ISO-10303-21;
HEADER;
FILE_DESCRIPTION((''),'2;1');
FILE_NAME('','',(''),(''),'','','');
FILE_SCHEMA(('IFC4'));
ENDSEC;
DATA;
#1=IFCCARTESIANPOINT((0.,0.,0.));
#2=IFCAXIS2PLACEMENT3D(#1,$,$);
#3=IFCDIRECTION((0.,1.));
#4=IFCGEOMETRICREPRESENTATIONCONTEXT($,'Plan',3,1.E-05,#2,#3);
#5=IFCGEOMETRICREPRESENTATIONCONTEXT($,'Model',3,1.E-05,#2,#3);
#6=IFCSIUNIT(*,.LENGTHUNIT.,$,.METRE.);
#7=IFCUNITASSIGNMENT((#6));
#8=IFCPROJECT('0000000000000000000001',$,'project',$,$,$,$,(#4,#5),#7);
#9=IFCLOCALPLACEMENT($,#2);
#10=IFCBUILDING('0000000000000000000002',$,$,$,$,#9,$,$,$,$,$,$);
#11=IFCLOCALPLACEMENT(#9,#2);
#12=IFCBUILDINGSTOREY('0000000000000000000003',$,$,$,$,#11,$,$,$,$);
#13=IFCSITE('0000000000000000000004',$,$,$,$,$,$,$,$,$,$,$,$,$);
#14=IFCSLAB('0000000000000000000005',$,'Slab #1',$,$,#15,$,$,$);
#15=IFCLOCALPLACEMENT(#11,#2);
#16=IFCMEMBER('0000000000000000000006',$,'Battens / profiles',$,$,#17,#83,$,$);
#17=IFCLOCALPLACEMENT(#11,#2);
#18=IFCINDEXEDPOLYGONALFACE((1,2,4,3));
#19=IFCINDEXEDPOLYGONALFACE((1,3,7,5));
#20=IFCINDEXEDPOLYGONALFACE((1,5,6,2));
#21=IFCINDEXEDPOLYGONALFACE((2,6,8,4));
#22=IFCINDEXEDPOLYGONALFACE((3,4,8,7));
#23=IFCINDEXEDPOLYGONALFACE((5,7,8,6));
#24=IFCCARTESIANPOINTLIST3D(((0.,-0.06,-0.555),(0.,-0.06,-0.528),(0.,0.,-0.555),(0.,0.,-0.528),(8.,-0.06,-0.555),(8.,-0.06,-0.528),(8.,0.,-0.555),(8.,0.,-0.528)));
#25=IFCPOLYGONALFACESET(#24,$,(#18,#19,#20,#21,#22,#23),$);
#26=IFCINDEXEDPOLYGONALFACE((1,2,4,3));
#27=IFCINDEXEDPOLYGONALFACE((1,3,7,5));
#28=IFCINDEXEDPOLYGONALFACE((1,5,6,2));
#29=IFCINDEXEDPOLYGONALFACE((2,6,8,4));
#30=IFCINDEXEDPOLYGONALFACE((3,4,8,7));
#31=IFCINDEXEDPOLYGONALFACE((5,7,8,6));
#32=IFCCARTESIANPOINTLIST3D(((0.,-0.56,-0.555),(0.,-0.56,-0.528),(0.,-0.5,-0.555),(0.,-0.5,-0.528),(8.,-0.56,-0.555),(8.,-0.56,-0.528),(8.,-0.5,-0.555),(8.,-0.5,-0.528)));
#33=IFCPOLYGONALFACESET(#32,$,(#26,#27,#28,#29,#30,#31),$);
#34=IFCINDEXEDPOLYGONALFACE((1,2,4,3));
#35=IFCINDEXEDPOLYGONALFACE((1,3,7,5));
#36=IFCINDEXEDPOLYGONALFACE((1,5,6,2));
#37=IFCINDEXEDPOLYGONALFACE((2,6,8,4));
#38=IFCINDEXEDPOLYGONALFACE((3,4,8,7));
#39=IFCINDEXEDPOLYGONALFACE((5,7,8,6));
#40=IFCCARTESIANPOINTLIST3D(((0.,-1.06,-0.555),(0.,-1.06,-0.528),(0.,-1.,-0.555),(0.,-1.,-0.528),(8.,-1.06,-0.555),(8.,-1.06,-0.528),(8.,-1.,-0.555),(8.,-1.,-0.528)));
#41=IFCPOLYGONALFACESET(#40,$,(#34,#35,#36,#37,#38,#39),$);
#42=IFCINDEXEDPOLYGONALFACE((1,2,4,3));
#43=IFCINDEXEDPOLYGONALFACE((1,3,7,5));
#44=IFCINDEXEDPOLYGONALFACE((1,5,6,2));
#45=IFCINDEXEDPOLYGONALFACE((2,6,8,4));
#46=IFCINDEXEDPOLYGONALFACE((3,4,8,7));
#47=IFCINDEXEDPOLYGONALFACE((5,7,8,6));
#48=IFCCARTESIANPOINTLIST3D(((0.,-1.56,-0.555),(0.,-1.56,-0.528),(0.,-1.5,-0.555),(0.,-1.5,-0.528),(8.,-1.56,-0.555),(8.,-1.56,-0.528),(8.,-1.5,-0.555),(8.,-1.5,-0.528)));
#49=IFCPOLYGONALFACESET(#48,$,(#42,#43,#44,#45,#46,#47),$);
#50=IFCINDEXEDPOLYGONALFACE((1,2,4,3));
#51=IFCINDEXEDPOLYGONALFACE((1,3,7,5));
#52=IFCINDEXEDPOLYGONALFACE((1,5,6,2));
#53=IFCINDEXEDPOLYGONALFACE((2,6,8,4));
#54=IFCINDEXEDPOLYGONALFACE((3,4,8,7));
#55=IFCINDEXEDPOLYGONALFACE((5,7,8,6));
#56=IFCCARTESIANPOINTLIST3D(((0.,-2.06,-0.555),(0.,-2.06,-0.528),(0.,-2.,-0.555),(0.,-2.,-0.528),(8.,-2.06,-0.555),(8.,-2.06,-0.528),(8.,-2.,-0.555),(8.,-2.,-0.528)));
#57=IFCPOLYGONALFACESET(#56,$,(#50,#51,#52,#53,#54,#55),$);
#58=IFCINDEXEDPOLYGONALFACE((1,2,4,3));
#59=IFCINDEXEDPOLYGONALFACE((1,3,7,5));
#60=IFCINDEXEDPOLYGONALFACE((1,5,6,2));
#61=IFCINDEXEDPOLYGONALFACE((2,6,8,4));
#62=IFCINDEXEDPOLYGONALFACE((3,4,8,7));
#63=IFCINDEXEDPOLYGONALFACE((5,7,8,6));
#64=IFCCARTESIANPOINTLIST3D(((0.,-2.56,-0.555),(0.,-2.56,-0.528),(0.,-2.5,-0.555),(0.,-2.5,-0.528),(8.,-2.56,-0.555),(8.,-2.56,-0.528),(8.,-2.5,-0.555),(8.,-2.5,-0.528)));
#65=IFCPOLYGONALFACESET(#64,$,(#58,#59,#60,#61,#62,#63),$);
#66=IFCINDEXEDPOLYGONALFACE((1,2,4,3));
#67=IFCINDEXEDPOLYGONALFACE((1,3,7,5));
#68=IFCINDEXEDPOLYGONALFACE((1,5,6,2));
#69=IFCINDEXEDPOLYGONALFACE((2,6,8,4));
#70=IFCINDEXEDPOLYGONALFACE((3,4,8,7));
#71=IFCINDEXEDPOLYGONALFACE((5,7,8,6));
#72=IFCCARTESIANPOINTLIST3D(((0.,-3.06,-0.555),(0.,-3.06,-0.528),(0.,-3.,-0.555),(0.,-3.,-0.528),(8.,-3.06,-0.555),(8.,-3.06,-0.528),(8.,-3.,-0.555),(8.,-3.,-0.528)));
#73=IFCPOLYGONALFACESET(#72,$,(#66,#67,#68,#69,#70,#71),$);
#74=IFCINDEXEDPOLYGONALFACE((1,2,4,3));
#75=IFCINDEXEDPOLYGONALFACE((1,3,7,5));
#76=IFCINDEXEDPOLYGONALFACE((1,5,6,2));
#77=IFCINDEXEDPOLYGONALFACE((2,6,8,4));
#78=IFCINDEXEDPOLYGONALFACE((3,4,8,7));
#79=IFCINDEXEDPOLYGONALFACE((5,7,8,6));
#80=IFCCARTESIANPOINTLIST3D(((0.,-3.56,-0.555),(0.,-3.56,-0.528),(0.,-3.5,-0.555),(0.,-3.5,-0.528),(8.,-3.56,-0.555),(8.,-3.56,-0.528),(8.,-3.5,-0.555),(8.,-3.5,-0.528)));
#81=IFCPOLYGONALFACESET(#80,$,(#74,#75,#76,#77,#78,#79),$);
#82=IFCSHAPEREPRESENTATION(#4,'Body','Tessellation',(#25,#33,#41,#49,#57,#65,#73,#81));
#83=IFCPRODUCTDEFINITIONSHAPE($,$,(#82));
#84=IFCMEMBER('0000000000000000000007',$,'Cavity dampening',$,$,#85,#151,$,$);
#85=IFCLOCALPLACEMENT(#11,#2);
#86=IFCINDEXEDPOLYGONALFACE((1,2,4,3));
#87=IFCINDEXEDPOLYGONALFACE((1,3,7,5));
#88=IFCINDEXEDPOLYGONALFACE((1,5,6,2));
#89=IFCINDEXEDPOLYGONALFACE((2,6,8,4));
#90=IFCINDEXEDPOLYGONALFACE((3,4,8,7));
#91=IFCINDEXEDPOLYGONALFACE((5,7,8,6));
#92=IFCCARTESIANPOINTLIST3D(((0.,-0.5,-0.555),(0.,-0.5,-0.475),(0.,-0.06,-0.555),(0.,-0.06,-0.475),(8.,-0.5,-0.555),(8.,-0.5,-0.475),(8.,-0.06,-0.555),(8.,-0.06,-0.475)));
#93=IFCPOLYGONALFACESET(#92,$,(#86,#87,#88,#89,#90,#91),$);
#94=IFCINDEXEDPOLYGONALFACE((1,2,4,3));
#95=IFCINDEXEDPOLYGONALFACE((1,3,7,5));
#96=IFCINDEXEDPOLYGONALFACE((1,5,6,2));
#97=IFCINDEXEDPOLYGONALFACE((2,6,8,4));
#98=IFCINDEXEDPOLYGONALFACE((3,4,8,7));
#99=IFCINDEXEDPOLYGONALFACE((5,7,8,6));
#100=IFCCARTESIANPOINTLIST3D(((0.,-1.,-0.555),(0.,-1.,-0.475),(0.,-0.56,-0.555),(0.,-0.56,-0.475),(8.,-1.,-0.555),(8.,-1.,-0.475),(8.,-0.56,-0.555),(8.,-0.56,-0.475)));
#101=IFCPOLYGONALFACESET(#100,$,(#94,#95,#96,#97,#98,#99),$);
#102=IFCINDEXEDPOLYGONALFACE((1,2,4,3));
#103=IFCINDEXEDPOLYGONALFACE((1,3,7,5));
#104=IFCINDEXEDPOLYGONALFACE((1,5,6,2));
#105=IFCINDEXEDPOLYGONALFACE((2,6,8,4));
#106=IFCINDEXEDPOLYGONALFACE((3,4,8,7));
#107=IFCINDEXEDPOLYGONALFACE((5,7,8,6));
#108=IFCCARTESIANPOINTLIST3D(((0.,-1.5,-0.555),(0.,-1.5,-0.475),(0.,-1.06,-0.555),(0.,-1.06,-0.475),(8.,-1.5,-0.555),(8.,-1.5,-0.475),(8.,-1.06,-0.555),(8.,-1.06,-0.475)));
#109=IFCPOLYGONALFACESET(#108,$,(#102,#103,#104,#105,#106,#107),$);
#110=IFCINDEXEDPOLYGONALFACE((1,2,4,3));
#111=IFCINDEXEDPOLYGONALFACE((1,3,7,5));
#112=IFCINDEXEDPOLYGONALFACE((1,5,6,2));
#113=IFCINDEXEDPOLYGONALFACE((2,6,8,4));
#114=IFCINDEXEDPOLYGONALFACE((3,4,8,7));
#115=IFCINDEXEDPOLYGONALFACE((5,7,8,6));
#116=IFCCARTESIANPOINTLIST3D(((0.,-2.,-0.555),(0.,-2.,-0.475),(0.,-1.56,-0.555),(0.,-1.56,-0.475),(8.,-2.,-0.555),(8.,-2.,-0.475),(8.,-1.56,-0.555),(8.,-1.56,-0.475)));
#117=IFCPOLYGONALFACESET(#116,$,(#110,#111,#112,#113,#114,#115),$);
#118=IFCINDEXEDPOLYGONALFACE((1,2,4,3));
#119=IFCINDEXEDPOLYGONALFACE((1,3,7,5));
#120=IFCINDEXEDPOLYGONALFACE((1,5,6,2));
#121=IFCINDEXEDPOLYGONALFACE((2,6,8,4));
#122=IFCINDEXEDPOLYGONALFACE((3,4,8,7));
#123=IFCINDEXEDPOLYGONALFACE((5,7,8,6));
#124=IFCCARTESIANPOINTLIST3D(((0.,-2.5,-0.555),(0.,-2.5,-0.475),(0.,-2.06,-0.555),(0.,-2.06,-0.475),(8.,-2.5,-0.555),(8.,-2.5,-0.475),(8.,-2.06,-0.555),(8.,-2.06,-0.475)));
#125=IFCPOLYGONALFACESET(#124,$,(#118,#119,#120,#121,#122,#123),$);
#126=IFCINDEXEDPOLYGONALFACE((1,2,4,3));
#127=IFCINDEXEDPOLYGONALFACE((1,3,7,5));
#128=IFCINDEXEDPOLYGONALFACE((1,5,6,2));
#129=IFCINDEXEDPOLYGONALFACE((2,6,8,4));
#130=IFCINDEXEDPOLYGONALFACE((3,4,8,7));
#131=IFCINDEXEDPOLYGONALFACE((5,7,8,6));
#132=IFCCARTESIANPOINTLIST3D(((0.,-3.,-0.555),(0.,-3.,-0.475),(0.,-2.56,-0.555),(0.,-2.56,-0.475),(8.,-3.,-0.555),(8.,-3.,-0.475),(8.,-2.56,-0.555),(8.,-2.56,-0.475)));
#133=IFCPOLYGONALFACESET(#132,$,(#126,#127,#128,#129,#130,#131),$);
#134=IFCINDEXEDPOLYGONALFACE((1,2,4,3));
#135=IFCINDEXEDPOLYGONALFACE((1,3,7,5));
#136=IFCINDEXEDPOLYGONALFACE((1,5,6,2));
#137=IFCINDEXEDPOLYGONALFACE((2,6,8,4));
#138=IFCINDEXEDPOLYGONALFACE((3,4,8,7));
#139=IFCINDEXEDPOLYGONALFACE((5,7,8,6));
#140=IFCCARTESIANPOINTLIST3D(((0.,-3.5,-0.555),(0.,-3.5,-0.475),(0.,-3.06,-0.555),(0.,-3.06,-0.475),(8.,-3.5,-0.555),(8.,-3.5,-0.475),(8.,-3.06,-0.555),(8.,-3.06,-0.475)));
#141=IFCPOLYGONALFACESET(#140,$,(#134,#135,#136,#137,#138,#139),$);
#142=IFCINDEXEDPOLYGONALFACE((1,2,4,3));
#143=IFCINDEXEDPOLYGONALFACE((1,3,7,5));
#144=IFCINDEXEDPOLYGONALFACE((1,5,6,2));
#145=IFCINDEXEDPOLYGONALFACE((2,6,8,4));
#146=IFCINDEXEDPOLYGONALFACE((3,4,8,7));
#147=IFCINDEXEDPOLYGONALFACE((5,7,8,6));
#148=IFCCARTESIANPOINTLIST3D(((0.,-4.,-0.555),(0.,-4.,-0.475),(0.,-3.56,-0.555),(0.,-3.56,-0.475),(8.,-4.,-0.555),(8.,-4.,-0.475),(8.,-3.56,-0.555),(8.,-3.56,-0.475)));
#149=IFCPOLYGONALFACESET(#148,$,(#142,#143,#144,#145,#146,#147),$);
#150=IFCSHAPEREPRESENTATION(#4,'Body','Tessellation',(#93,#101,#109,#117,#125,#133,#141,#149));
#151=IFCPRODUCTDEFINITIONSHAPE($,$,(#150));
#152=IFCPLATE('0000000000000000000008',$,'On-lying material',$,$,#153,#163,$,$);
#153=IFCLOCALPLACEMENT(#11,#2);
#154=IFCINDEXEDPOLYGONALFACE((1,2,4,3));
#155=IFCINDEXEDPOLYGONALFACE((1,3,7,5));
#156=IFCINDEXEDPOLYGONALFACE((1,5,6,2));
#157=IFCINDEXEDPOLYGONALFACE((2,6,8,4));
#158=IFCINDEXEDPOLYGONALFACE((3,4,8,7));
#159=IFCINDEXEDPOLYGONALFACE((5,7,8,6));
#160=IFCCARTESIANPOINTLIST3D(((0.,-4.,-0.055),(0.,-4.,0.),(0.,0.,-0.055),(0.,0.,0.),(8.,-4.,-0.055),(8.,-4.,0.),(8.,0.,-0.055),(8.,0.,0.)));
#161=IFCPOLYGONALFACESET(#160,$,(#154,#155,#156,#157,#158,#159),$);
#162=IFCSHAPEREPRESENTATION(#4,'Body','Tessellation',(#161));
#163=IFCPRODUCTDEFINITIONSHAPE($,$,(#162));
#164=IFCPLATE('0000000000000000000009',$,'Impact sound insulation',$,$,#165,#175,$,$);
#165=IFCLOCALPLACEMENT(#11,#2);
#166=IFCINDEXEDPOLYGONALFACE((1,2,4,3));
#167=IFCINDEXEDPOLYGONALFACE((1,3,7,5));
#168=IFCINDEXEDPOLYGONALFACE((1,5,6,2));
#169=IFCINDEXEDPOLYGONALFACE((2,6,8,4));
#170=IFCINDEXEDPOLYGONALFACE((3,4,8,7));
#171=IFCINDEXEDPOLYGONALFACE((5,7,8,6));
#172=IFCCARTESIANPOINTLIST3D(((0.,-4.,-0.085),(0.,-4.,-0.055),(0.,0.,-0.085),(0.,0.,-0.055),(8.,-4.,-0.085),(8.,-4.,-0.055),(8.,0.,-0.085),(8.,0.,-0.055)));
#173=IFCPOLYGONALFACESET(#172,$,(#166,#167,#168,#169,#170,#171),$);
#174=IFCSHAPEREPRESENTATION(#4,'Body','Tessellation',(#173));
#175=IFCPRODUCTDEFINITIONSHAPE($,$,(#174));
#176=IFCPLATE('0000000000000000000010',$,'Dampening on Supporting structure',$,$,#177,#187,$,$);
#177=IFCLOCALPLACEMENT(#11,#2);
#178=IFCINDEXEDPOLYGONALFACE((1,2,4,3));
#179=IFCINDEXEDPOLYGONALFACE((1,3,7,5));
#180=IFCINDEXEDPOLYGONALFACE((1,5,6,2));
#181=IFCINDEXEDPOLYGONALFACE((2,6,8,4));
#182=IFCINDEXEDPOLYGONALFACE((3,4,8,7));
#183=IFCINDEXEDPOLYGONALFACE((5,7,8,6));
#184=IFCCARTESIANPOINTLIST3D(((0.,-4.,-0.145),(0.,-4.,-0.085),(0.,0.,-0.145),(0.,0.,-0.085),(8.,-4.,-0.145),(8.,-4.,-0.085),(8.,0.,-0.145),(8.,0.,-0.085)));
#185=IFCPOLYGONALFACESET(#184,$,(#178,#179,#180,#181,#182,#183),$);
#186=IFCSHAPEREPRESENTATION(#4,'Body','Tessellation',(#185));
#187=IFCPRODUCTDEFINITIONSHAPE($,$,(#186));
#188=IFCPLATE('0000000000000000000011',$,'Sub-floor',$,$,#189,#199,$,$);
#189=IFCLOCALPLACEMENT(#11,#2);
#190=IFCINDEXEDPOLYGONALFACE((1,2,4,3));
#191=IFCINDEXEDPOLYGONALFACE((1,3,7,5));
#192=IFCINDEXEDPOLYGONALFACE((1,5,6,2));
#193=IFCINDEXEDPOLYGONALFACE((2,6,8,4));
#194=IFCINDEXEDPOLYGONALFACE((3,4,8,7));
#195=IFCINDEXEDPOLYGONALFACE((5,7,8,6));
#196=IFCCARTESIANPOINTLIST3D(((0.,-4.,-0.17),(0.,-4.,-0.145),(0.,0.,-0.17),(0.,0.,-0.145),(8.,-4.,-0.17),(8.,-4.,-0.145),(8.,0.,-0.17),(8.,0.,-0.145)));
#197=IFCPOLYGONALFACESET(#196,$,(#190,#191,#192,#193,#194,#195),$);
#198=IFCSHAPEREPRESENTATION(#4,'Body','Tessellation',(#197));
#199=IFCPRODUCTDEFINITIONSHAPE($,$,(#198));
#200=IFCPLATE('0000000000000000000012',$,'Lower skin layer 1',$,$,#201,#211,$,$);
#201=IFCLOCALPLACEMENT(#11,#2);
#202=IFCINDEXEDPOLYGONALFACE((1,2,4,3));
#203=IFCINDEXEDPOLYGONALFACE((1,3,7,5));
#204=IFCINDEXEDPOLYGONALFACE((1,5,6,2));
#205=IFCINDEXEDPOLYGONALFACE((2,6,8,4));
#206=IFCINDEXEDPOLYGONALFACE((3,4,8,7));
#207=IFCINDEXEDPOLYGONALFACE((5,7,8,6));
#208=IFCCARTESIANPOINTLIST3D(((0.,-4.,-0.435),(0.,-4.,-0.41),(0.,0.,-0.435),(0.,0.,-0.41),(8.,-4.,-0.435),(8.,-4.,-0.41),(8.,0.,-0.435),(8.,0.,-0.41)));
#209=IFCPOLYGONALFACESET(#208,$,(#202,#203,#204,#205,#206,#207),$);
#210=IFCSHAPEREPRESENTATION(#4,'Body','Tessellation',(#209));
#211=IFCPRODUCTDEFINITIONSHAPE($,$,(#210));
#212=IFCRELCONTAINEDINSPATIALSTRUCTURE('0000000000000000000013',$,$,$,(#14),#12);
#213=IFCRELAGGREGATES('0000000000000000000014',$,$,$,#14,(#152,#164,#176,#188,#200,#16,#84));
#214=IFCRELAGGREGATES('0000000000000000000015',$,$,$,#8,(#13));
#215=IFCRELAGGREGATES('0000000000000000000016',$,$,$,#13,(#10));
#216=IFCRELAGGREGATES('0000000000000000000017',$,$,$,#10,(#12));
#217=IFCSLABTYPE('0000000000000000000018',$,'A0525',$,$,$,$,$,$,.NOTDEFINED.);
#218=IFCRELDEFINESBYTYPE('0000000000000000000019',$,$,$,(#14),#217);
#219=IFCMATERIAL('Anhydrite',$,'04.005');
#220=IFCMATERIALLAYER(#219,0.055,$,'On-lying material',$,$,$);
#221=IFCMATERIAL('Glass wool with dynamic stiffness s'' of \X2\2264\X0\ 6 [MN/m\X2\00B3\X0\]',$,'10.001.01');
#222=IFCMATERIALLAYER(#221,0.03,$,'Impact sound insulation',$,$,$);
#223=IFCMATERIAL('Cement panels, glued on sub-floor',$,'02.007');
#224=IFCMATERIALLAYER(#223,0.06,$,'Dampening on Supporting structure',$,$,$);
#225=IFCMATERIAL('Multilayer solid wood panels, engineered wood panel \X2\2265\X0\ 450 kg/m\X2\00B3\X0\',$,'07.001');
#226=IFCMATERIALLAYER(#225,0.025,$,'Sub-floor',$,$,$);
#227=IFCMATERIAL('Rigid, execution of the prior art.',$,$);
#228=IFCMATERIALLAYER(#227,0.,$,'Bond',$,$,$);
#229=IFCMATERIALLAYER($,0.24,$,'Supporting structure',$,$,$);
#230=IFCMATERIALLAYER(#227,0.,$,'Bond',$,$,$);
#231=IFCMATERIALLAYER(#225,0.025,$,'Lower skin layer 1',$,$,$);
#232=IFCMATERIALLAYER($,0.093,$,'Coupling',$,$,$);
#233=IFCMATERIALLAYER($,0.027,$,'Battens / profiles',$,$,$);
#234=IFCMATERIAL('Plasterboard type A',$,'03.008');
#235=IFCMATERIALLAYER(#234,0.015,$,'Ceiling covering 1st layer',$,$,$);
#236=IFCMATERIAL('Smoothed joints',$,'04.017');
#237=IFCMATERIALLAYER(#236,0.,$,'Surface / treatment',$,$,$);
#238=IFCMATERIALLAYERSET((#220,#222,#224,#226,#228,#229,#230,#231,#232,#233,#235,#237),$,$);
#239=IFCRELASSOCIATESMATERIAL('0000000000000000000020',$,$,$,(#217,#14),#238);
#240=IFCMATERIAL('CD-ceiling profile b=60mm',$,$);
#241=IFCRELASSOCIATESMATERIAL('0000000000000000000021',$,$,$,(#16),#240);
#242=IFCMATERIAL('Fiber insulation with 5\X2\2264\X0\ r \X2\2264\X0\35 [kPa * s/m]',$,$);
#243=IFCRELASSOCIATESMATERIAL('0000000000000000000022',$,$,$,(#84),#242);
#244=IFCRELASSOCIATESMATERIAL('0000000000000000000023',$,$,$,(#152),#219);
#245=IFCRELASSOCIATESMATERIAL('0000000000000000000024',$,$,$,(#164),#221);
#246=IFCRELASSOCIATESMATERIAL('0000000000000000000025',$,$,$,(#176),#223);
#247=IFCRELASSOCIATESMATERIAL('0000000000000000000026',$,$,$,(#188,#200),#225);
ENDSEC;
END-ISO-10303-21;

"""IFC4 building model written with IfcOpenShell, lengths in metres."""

from ifc_helpers import new_model, si_unit, direction, frame, frame_2d, origin, origin_with_axes, place, context, project, spatial, rectangle, extrude, material, layer, layer_set, type_object, element, aggregate, save


model = new_model("IFC4")

# Units and contexts
plan_context = context("Plan", 3, precision=1e-05, world=origin(), true_north=direction((0.0, 1.0)))
model_context = context("Model", 3, precision=1e-05, world=origin(), true_north=direction((0.0, 1.0)))
ifc_project = project(units=[si_unit("LENGTHUNIT", "METRE")], contexts=[plan_context, model_context])

# Site, building, storey
site = spatial("IfcSite", under=ifc_project)
building_placement = place(None, origin())
building = spatial("IfcBuilding", under=site, at=building_placement)
storey_placement = place(building_placement, origin())
storey = spatial("IfcBuildingStorey", under=building, at=storey_placement)

# Slab, members, plates
ifc_material_1 = material(Name="Anhydrite", Category="04.005")
ifc_layer_1 = layer(ifc_material_1, 0.055, Name="On-lying material")
ifc_material_2 = material(Name="Glass wool with dynamic stiffness s' of ≤ 6 [MN/m³]", Category="10.001.01")
ifc_layer_2 = layer(ifc_material_2, 0.03, Name="Impact sound insulation")
ifc_material_3 = material(Name="Cement panels, glued on sub-floor", Category="02.007")
ifc_layer_3 = layer(ifc_material_3, 0.06, Name="Dampening on Supporting structure")
ifc_material_4 = material(Name="Multilayer solid wood panels, engineered wood panel ≥ 450 kg/m³", Category="07.001")
ifc_layer_4 = layer(ifc_material_4, 0.025, Name="Sub-floor")
ifc_material_5 = material(Name="Rigid, execution of the prior art.")
ifc_layer_5 = layer(ifc_material_5, 0.0, Name="Bond")
ifc_layer_6 = layer(None, 0.24, Name="Supporting structure")
ifc_layer_7 = layer(ifc_material_5, 0.0, Name="Bond")
ifc_layer_8 = layer(ifc_material_4, 0.025, Name="Lower skin layer 1")
ifc_layer_9 = layer(None, 0.093, Name="Coupling")
ifc_layer_10 = layer(None, 0.027, Name="Battens / profiles")
ifc_material_6 = material(Name="Plasterboard type A", Category="03.008")
ifc_layer_11 = layer(ifc_material_6, 0.015, Name="Ceiling covering 1st layer")
ifc_material_7 = material(Name="Smoothed joints", Category="04.017")
ifc_layer_12 = layer(ifc_material_7, 0.0, Name="Surface / treatment")
ifc_layer_set = layer_set([ifc_layer_1, ifc_layer_2, ifc_layer_3, ifc_layer_4, ifc_layer_5, ifc_layer_6, ifc_layer_7, ifc_layer_8, ifc_layer_9, ifc_layer_10, ifc_layer_11, ifc_layer_12])
slab_type = type_object("IfcSlabType", Name="A0525", PredefinedType="NOTDEFINED", material=ifc_layer_set)
slab_placement = place(None, frame((0.0, 0.0, 0.0), z_axis=(0.0, 0.0, -1.0), x_axis=(1.0, 0.0, 0.0)))
slab = element("IfcSlab", 1, at=slab_placement, inside=storey, type_object=slab_type, material=ifc_layer_set, Name="Slab #1")
ifc_material_8 = material(Name="Fiber insulation with 5≤ r ≤35 [kPa * s/m]")
ifc_material_9 = material(Name="CD-ceiling profile b=60mm")
member_1_placement = place(slab_placement, origin())
member_1 = element("IfcMember", 2, at=member_1_placement, material=ifc_material_9, Name="Battens / profiles", context=plan_context, shape_type="SweptSolid", body=[
    extrude(rectangle(XDim=0.06, YDim=0.027, at=frame_2d((0.03, 0.0135), x_axis=(1.0, 0.0))), frame((0.0, 0.0, 0.528), z_axis=(1.0, 0.0, 0.0), x_axis=(0.0, 1.0, 0.0)), (0.0, 0.0, 1.0), 8.0),
    extrude(rectangle(XDim=0.06, YDim=0.027, at=frame_2d((0.03, 0.0135), x_axis=(1.0, 0.0))), frame((0.0, 0.5, 0.528), z_axis=(1.0, 0.0, 0.0), x_axis=(0.0, 1.0, 0.0)), (0.0, 0.0, 1.0), 8.0),
    extrude(rectangle(XDim=0.06, YDim=0.027, at=frame_2d((0.03, 0.0135), x_axis=(1.0, 0.0))), frame((0.0, 1.0, 0.528), z_axis=(1.0, 0.0, 0.0), x_axis=(0.0, 1.0, 0.0)), (0.0, 0.0, 1.0), 8.0),
    extrude(rectangle(XDim=0.06, YDim=0.027, at=frame_2d((0.03, 0.0135), x_axis=(1.0, 0.0))), frame((0.0, 1.5, 0.528), z_axis=(1.0, 0.0, 0.0), x_axis=(0.0, 1.0, 0.0)), (0.0, 0.0, 1.0), 8.0),
    extrude(rectangle(XDim=0.06, YDim=0.027, at=frame_2d((0.03, 0.0135), x_axis=(1.0, 0.0))), frame((0.0, 2.0, 0.528), z_axis=(1.0, 0.0, 0.0), x_axis=(0.0, 1.0, 0.0)), (0.0, 0.0, 1.0), 8.0),
    extrude(rectangle(XDim=0.06, YDim=0.027, at=frame_2d((0.03, 0.0135), x_axis=(1.0, 0.0))), frame((0.0, 2.5, 0.528), z_axis=(1.0, 0.0, 0.0), x_axis=(0.0, 1.0, 0.0)), (0.0, 0.0, 1.0), 8.0),
    extrude(rectangle(XDim=0.06, YDim=0.027, at=frame_2d((0.03, 0.0135), x_axis=(1.0, 0.0))), frame((0.0, 3.0, 0.528), z_axis=(1.0, 0.0, 0.0), x_axis=(0.0, 1.0, 0.0)), (0.0, 0.0, 1.0), 8.0),
    extrude(rectangle(XDim=0.06, YDim=0.027, at=frame_2d((0.03, 0.0135), x_axis=(1.0, 0.0))), frame((0.0, 3.5, 0.528), z_axis=(1.0, 0.0, 0.0), x_axis=(0.0, 1.0, 0.0)), (0.0, 0.0, 1.0), 8.0),
])
member_2_placement = place(slab_placement, origin())
member_2 = element("IfcMember", 3, at=member_2_placement, material=ifc_material_8, Name="Cavity dampening", context=plan_context, shape_type="SweptSolid", body=[
    extrude(rectangle(XDim=0.44, YDim=0.08, at=frame_2d((0.22, 0.04), x_axis=(1.0, 0.0))), frame((0.0, 0.06, 0.475), z_axis=(1.0, 0.0, 0.0), x_axis=(0.0, 1.0, 0.0)), (0.0, 0.0, 1.0), 8.0),
    extrude(rectangle(XDim=0.44, YDim=0.08, at=frame_2d((0.22, 0.04), x_axis=(1.0, 0.0))), frame((0.0, 0.56, 0.475), z_axis=(1.0, 0.0, 0.0), x_axis=(0.0, 1.0, 0.0)), (0.0, 0.0, 1.0), 8.0),
    extrude(rectangle(XDim=0.44, YDim=0.08, at=frame_2d((0.22, 0.04), x_axis=(1.0, 0.0))), frame((0.0, 1.06, 0.475), z_axis=(1.0, 0.0, 0.0), x_axis=(0.0, 1.0, 0.0)), (0.0, 0.0, 1.0), 8.0),
    extrude(rectangle(XDim=0.44, YDim=0.08, at=frame_2d((0.22, 0.04), x_axis=(1.0, 0.0))), frame((0.0, 1.56, 0.475), z_axis=(1.0, 0.0, 0.0), x_axis=(0.0, 1.0, 0.0)), (0.0, 0.0, 1.0), 8.0),
    extrude(rectangle(XDim=0.44, YDim=0.08, at=frame_2d((0.22, 0.04), x_axis=(1.0, 0.0))), frame((0.0, 2.06, 0.475), z_axis=(1.0, 0.0, 0.0), x_axis=(0.0, 1.0, 0.0)), (0.0, 0.0, 1.0), 8.0),
    extrude(rectangle(XDim=0.44, YDim=0.08, at=frame_2d((0.22, 0.04), x_axis=(1.0, 0.0))), frame((0.0, 2.56, 0.475), z_axis=(1.0, 0.0, 0.0), x_axis=(0.0, 1.0, 0.0)), (0.0, 0.0, 1.0), 8.0),
    extrude(rectangle(XDim=0.44, YDim=0.08, at=frame_2d((0.22, 0.04), x_axis=(1.0, 0.0))), frame((0.0, 3.06, 0.475), z_axis=(1.0, 0.0, 0.0), x_axis=(0.0, 1.0, 0.0)), (0.0, 0.0, 1.0), 8.0),
    extrude(rectangle(XDim=0.44, YDim=0.08, at=frame_2d((0.22, 0.04), x_axis=(1.0, 0.0))), frame((0.0, 3.56, 0.475), z_axis=(1.0, 0.0, 0.0), x_axis=(0.0, 1.0, 0.0)), (0.0, 0.0, 1.0), 8.0),
])
plate_1_placement = place(slab_placement, origin())
plate_1 = element("IfcPlate", 4, at=plate_1_placement, material=ifc_material_1, Name="On-lying material", context=plan_context, shape_type="SweptSolid", body=[
    extrude(rectangle(XDim=8.0, YDim=4.0, at=frame_2d((4.0, 2.0), x_axis=(1.0, 0.0))), origin_with_axes(), (0.0, 0.0, 1.0), 0.055),
])
plate_2_placement = place(slab_placement, origin())
plate_2 = element("IfcPlate", 5, at=plate_2_placement, material=ifc_material_2, Name="Impact sound insulation", context=plan_context, shape_type="SweptSolid", body=[
    extrude(rectangle(XDim=8.0, YDim=4.0, at=frame_2d((4.0, 2.0), x_axis=(1.0, 0.0))), frame((0.0, 0.0, 0.055), z_axis=(0.0, 0.0, 1.0), x_axis=(1.0, 0.0, 0.0)), (0.0, 0.0, 1.0), 0.03),
])
plate_3_placement = place(slab_placement, origin())
plate_3 = element("IfcPlate", 6, at=plate_3_placement, material=ifc_material_3, Name="Dampening on Supporting structure", context=plan_context, shape_type="SweptSolid", body=[
    extrude(rectangle(XDim=8.0, YDim=4.0, at=frame_2d((4.0, 2.0), x_axis=(1.0, 0.0))), frame((0.0, 0.0, 0.085), z_axis=(0.0, 0.0, 1.0), x_axis=(1.0, 0.0, 0.0)), (0.0, 0.0, 1.0), 0.06),
])
plate_4_placement = place(slab_placement, origin())
plate_4 = element("IfcPlate", 7, at=plate_4_placement, material=ifc_material_4, Name="Sub-floor", context=plan_context, shape_type="SweptSolid", body=[
    extrude(rectangle(XDim=8.0, YDim=4.0, at=frame_2d((4.0, 2.0), x_axis=(1.0, 0.0))), frame((0.0, 0.0, 0.145), z_axis=(0.0, 0.0, 1.0), x_axis=(1.0, 0.0, 0.0)), (0.0, 0.0, 1.0), 0.025),
])
plate_5_placement = place(slab_placement, origin())
plate_5 = element("IfcPlate", 8, at=plate_5_placement, material=ifc_material_4, Name="Lower skin layer 1", context=plan_context, shape_type="SweptSolid", body=[
    extrude(rectangle(XDim=8.0, YDim=4.0, at=frame_2d((4.0, 2.0), x_axis=(1.0, 0.0))), frame((0.0, 0.0, 0.41), z_axis=(0.0, 0.0, 1.0), x_axis=(1.0, 0.0, 0.0)), (0.0, 0.0, 1.0), 0.025),
])
aggregate(slab, [plate_1, plate_2, plate_3, plate_4, plate_5, member_1, member_2])

save(model, "model.ifc")
